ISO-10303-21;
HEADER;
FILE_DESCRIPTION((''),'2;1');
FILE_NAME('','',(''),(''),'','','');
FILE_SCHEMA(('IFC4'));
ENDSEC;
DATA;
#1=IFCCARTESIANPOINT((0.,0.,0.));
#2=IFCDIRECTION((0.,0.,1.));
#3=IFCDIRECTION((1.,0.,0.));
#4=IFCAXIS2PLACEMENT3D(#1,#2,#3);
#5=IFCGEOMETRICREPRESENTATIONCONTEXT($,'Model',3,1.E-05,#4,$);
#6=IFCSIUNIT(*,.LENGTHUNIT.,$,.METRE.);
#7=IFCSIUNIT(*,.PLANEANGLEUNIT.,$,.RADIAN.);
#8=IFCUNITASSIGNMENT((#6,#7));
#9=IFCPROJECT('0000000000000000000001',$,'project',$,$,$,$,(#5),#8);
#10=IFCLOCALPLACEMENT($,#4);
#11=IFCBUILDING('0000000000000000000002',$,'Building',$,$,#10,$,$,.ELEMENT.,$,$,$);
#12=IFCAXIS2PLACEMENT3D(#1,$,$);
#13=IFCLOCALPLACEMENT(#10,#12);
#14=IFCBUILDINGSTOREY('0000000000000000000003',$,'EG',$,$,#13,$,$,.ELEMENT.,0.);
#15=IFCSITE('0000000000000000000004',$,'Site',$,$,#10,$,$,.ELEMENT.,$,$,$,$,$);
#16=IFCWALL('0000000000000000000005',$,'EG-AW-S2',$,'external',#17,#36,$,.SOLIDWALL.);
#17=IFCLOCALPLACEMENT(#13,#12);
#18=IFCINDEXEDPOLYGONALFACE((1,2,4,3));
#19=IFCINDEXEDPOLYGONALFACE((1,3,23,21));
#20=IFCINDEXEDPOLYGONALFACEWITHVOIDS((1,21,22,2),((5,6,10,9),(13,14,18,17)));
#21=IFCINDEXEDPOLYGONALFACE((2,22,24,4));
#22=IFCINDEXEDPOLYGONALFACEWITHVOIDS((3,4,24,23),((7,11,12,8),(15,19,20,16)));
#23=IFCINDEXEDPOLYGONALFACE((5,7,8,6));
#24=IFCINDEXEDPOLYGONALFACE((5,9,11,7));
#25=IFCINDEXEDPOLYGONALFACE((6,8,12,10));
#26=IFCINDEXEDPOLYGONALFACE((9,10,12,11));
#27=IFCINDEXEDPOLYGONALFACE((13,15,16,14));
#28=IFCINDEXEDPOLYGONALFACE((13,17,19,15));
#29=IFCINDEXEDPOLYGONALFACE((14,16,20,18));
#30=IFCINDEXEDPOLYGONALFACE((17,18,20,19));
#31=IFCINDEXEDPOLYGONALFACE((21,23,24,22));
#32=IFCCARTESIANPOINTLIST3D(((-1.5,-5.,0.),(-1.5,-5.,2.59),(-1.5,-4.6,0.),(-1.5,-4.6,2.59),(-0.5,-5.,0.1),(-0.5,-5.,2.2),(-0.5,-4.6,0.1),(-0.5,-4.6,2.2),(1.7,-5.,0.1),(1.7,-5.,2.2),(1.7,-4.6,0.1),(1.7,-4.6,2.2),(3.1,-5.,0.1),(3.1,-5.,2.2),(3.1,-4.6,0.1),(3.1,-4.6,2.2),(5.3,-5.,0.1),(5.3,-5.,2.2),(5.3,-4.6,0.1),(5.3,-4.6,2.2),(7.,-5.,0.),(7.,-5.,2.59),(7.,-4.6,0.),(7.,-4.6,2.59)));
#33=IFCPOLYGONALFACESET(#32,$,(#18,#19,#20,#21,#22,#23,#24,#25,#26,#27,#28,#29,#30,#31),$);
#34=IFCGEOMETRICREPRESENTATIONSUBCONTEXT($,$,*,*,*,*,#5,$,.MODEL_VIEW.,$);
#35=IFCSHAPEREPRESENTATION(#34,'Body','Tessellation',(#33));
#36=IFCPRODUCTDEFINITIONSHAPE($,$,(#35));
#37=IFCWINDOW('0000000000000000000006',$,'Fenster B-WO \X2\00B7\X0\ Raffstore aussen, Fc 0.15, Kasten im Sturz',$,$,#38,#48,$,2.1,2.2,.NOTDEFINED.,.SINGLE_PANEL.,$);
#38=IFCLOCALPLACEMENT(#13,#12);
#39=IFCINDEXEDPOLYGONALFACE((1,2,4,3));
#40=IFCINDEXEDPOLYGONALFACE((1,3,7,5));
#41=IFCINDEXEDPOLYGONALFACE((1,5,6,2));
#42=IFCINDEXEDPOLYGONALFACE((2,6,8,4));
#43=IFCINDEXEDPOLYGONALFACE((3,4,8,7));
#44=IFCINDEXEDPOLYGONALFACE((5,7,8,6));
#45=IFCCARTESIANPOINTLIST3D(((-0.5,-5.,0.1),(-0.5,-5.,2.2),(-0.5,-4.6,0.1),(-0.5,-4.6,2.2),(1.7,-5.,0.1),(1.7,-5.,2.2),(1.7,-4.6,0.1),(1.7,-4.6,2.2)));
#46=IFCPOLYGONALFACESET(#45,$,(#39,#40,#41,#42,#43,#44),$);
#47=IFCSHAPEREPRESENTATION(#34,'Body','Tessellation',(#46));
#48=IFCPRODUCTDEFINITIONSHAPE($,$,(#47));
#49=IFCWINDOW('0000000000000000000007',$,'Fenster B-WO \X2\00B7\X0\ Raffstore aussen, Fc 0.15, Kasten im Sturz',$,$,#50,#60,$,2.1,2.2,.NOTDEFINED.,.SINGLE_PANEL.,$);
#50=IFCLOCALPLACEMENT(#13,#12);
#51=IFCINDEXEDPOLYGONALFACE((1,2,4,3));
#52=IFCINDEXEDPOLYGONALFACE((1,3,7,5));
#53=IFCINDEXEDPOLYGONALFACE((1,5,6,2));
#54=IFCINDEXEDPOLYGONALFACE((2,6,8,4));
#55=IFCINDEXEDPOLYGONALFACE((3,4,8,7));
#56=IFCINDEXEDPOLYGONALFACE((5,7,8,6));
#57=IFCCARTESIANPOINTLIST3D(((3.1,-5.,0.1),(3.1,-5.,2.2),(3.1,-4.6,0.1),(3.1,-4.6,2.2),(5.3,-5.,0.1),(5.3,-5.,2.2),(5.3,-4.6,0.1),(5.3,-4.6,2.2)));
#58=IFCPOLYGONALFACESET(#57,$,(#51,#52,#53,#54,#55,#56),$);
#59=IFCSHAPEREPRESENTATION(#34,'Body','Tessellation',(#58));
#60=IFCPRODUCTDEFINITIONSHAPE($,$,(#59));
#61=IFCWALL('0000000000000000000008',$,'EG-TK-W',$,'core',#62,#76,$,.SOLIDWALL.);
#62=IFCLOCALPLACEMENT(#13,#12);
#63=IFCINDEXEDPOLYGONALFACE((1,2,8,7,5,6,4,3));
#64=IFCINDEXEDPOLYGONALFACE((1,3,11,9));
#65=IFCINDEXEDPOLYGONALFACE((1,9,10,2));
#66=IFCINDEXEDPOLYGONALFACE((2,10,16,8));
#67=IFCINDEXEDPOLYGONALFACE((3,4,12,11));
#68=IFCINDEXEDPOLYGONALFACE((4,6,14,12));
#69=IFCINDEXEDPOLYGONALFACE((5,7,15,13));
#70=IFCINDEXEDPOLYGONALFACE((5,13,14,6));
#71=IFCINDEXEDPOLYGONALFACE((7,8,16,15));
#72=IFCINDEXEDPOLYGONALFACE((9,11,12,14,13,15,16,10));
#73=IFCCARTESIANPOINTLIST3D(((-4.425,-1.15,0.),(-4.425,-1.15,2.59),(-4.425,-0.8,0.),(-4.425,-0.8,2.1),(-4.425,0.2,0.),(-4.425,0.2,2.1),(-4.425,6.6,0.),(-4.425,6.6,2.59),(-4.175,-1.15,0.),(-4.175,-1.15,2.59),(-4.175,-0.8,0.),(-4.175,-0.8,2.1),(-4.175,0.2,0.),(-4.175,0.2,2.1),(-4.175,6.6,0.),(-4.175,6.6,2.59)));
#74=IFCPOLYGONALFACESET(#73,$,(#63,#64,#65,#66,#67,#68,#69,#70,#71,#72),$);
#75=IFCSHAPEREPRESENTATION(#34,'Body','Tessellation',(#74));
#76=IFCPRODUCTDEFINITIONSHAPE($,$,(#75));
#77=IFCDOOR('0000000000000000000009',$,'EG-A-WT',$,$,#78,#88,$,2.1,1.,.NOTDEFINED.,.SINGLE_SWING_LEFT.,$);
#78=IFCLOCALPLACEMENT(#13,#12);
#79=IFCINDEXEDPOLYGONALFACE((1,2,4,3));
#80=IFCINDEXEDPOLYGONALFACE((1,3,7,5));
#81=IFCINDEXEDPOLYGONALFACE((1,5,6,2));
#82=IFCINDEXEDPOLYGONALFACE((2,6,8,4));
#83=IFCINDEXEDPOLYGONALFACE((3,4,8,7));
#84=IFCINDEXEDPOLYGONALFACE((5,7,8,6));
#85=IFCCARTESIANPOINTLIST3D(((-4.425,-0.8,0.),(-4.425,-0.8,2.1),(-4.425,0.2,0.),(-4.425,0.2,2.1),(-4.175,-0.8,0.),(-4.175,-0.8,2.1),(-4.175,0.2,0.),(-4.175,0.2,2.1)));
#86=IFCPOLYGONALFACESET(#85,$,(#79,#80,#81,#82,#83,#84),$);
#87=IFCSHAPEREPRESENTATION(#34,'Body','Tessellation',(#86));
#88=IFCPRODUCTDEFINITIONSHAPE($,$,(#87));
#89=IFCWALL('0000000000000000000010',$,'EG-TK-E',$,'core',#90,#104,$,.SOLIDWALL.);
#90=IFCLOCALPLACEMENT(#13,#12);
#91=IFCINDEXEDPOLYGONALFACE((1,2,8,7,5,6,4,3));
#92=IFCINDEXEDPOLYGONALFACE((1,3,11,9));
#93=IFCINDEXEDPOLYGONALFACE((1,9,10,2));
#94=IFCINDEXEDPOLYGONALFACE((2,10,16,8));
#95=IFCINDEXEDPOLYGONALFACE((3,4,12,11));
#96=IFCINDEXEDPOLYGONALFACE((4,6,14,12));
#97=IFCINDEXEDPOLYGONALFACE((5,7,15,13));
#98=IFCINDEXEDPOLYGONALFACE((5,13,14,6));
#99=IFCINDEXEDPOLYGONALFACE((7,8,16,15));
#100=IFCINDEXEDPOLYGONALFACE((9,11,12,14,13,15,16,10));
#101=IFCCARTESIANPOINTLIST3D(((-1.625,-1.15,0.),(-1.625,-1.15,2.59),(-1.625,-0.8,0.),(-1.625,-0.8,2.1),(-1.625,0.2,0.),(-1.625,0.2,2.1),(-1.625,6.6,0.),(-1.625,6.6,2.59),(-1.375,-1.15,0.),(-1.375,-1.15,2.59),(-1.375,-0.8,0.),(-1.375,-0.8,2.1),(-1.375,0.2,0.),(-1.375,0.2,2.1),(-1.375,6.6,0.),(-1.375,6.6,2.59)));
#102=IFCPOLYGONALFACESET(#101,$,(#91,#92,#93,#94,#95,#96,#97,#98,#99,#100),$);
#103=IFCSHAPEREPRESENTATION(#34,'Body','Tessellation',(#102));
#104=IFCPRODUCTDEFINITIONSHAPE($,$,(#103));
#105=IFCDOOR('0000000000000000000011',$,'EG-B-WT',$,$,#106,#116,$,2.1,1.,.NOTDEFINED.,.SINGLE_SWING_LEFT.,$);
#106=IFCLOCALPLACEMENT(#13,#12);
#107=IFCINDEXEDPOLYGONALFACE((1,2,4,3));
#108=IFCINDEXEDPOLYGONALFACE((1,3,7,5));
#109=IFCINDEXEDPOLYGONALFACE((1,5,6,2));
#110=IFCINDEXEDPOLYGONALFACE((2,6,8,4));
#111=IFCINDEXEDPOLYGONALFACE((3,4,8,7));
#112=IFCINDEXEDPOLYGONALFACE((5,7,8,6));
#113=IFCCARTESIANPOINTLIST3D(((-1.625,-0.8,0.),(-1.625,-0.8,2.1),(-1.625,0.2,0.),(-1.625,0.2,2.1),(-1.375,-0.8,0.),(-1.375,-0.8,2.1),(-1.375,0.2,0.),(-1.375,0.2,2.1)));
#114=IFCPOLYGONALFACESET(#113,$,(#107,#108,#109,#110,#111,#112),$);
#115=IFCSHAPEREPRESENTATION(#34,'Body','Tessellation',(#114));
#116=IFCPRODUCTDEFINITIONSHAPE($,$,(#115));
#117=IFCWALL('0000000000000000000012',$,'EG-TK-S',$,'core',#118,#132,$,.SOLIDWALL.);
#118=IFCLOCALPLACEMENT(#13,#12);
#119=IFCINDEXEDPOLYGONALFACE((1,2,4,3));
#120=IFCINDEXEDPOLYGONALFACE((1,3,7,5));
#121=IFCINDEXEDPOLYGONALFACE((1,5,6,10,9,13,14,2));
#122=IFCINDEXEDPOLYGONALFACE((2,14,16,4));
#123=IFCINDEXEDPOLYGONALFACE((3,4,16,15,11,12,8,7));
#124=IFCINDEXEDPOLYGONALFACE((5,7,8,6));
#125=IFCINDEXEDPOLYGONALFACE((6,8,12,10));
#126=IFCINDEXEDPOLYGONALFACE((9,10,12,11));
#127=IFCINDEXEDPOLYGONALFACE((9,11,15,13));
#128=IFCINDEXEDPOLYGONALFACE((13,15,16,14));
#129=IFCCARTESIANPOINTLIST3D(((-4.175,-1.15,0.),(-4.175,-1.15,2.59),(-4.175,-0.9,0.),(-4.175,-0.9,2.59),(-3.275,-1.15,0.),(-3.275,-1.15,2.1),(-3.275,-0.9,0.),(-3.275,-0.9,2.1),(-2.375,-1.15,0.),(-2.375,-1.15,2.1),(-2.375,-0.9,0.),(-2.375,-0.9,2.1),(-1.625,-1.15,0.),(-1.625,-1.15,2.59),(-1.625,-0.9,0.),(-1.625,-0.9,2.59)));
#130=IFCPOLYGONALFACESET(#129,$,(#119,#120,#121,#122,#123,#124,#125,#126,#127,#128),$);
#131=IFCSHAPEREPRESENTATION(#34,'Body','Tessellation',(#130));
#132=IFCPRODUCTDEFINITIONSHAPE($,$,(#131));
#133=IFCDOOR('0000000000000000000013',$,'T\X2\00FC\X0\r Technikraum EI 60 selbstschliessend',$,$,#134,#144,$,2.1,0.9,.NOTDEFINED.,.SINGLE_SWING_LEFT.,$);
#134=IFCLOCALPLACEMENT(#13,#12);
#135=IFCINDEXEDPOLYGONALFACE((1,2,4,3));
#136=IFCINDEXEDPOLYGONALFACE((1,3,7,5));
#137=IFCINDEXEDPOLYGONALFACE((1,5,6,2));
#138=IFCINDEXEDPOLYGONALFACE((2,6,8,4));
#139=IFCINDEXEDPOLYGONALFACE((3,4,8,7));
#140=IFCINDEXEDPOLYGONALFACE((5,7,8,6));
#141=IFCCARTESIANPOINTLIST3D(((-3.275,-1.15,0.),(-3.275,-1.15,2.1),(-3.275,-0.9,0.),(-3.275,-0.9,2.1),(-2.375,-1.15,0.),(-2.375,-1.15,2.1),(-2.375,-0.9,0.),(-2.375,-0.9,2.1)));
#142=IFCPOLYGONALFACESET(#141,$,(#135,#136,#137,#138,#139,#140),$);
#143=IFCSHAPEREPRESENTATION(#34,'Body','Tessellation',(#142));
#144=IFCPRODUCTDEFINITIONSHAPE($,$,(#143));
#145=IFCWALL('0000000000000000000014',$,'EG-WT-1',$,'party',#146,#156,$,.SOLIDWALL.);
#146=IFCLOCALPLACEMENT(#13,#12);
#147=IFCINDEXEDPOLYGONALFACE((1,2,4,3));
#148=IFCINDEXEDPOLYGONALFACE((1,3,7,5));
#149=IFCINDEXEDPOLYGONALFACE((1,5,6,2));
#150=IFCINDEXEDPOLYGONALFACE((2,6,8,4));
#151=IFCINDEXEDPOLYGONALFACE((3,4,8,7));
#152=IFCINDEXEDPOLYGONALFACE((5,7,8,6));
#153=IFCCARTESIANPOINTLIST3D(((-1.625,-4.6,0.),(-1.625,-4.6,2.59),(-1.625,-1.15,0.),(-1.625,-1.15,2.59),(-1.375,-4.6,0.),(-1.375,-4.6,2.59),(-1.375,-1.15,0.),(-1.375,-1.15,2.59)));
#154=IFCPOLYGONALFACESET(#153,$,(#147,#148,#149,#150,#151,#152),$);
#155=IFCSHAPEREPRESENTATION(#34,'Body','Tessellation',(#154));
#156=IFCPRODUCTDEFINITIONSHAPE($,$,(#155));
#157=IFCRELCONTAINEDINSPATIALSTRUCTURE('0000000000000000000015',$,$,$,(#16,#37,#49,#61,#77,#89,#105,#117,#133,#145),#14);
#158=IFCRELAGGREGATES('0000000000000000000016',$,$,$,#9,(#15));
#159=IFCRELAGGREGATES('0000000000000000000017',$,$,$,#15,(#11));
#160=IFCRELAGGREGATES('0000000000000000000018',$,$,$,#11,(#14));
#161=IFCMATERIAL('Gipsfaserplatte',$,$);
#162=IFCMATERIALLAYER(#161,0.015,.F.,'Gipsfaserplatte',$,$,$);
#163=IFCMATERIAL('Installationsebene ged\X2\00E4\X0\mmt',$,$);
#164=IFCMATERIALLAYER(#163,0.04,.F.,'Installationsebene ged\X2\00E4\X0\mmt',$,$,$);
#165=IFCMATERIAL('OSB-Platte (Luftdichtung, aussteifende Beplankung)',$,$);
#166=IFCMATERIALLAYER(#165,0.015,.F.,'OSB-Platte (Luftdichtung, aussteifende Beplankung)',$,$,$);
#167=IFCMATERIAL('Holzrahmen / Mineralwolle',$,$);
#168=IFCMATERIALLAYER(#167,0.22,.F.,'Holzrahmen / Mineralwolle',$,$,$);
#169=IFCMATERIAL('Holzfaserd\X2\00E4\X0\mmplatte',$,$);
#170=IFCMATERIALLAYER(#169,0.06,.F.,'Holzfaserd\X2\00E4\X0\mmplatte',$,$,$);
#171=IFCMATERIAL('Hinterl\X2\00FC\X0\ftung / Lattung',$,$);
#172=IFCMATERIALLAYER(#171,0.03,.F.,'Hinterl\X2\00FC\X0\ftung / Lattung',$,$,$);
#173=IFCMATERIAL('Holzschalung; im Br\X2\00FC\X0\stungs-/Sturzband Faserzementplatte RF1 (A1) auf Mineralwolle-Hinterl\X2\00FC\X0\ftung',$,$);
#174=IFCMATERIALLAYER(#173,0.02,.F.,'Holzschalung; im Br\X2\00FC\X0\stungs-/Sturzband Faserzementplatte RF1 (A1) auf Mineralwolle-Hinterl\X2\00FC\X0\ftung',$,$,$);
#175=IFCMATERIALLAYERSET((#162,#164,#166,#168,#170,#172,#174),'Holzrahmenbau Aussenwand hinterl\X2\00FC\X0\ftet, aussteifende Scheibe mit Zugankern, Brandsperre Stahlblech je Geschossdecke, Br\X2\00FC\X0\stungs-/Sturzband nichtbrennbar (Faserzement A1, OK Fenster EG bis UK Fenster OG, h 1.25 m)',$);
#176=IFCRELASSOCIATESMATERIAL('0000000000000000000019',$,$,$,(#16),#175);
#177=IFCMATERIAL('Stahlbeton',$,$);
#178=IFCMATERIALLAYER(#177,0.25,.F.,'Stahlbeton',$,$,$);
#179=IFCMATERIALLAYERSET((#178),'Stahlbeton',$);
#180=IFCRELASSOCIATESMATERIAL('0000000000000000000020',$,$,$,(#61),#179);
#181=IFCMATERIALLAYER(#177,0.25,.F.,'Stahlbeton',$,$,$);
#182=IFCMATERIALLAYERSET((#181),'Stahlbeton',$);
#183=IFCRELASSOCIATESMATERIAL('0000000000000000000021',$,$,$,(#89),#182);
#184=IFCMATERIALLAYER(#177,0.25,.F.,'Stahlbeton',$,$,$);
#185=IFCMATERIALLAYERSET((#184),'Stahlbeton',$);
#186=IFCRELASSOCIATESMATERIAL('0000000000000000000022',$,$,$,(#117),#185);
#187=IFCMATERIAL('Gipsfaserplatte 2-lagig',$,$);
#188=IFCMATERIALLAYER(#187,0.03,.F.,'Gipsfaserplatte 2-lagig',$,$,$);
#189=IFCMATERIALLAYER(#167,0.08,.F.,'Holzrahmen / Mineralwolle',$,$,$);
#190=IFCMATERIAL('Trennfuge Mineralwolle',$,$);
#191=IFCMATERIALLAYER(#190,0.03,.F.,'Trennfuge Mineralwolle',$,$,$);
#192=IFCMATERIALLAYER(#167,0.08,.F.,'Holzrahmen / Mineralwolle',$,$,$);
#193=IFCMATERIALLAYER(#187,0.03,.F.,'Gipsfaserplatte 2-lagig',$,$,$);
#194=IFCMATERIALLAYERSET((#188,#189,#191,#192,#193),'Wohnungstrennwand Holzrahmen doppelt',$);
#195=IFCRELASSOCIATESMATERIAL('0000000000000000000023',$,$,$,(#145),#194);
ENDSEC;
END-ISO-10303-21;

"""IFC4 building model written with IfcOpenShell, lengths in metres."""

from ifc_helpers import new_model, si_unit, frame, frame_2d, origin, origin_with_axes, place, context, subcontext, project, spatial, rectangle, extrude, material, layer, layer_set, element, fill, save


model = new_model("IFC4")

# Units and contexts
model_context = context("Model", 3, precision=1e-05, world=origin_with_axes())
sub_context = subcontext(model_context, None, None, "MODEL_VIEW")
ifc_project = project(units=[si_unit("LENGTHUNIT", "METRE"), si_unit("PLANEANGLEUNIT", "RADIAN")], contexts=[model_context])

# Site, building, storey
placement = place(None, origin_with_axes())
site = spatial("IfcSite", under=ifc_project, at=placement, Name="Site", CompositionType="ELEMENT")
building = spatial("IfcBuilding", under=site, at=placement, Name="Building", CompositionType="ELEMENT")
storey_placement = place(placement, origin())
storey = spatial("IfcBuildingStorey", under=building, at=storey_placement, Name="EG", CompositionType="ELEMENT", Elevation=0.0)

# Wall, openings, windows
ifc_material_1 = material(Name="Gipsfaserplatte")
ifc_layer_1 = layer(ifc_material_1, 0.015, ventilated=False, Name="Gipsfaserplatte")
ifc_material_2 = material(Name="Installationsebene gedämmt")
ifc_layer_2 = layer(ifc_material_2, 0.04, ventilated=False, Name="Installationsebene gedämmt")
ifc_material_3 = material(Name="OSB-Platte (Luftdichtung, aussteifende Beplankung)")
ifc_layer_3 = layer(ifc_material_3, 0.015, ventilated=False, Name="OSB-Platte (Luftdichtung, aussteifende Beplankung)")
ifc_material_4 = material(Name="Holzrahmen / Mineralwolle")
ifc_layer_4 = layer(ifc_material_4, 0.22, ventilated=False, Name="Holzrahmen / Mineralwolle")
ifc_material_5 = material(Name="Holzfaserdämmplatte")
ifc_layer_5 = layer(ifc_material_5, 0.06, ventilated=False, Name="Holzfaserdämmplatte")
ifc_material_6 = material(Name="Hinterlüftung / Lattung")
ifc_layer_6 = layer(ifc_material_6, 0.03, ventilated=False, Name="Hinterlüftung / Lattung")
ifc_material_7 = material(Name="Holzschalung; im Brüstungs-/Sturzband Faserzementplatte RF1 (A1) auf Mineralwolle-Hinterlüftung")
ifc_layer_7 = layer(ifc_material_7, 0.02, ventilated=False, Name="Holzschalung; im Brüstungs-/Sturzband Faserzementplatte RF1 (A1) auf Mineralwolle-Hinterlüftung")
ifc_layer_set_1 = layer_set([ifc_layer_1, ifc_layer_2, ifc_layer_3, ifc_layer_4, ifc_layer_5, ifc_layer_6, ifc_layer_7], Name="Holzrahmenbau Aussenwand hinterlüftet, aussteifende Scheibe mit Zugankern, Brandsperre Stahlblech je Geschossdecke, Brüstungs-/Sturzband nichtbrennbar (Faserzement A1, OK Fenster EG bis UK Fenster OG, h 1.25 m)")
wall_1_placement = place(storey_placement, frame((7.0, -4.8, 0.0), z_axis=(0.0, 0.0, 1.0), x_axis=(-1.0, 0.0, 0.0)))
wall_1 = element("IfcWall", 1, at=wall_1_placement, inside=storey, material=ifc_layer_set_1, Name="EG-AW-S2", ObjectType="external", PredefinedType="SOLIDWALL", context=sub_context, shape_type="SweptSolid", body=[
    extrude(rectangle(XDim=8.5, YDim=0.4, at=frame_2d((4.25, 0.0))), origin(), (0.0, 0.0, 1.0), 2.59),
])
opening_1_placement = place(wall_1_placement, frame((6.4, 0.25, 0.1), z_axis=(0.0, -1.0, 0.0), x_axis=(1.0, 0.0, 0.0)))
opening_1 = element("IfcOpeningElement", 2, at=opening_1_placement, cuts=wall_1, PredefinedType="OPENING", context=sub_context, shape_type="SweptSolid", body=[
    extrude(rectangle(XDim=2.2, YDim=2.1, at=frame_2d((0.0, 1.05))), origin(), (0.0, 0.0, 1.0), 0.5),
])
opening_2_placement = place(wall_1_placement, frame((2.8, 0.25, 0.1), z_axis=(0.0, -1.0, 0.0), x_axis=(1.0, 0.0, 0.0)))
opening_2 = element("IfcOpeningElement", 3, at=opening_2_placement, cuts=wall_1, PredefinedType="OPENING", context=sub_context, shape_type="SweptSolid", body=[
    extrude(rectangle(XDim=2.2, YDim=2.1, at=frame_2d((0.0, 1.05))), origin(), (0.0, 0.0, 1.0), 0.5),
])
window_1_placement = place(wall_1_placement, frame((6.4, 0.2, 0.1), z_axis=(0.0, -1.0, 0.0), x_axis=(1.0, 0.0, 0.0)))
window_1 = element("IfcWindow", 4, at=window_1_placement, inside=storey, Name="Fenster B-WO · Raffstore aussen, Fc 0.15, Kasten im Sturz", OverallHeight=2.1, OverallWidth=2.2, PartitioningType="SINGLE_PANEL", PredefinedType="NOTDEFINED", context=sub_context, shape_type="SweptSolid", body=[
    extrude(rectangle(XDim=2.2, YDim=2.1, at=frame_2d((0.0, 1.05))), origin(), (0.0, 0.0, 1.0), 0.4),
])
fill(opening_1, window_1)
window_2_placement = place(wall_1_placement, frame((2.8, 0.2, 0.1), z_axis=(0.0, -1.0, 0.0), x_axis=(1.0, 0.0, 0.0)))
window_2 = element("IfcWindow", 5, at=window_2_placement, inside=storey, Name="Fenster B-WO · Raffstore aussen, Fc 0.15, Kasten im Sturz", OverallHeight=2.1, OverallWidth=2.2, PartitioningType="SINGLE_PANEL", PredefinedType="NOTDEFINED", context=sub_context, shape_type="SweptSolid", body=[
    extrude(rectangle(XDim=2.2, YDim=2.1, at=frame_2d((0.0, 1.05))), origin(), (0.0, 0.0, 1.0), 0.4),
])
fill(opening_2, window_2)

# Walls, openings, doors
ifc_material_8 = material(Name="Stahlbeton")
ifc_layer_8 = layer(ifc_material_8, 0.25, ventilated=False, Name="Stahlbeton")
ifc_layer_set_2 = layer_set([ifc_layer_8], Name="Stahlbeton")
wall_2_placement = place(storey_placement, frame((-4.3, -1.15, 0.0), z_axis=(0.0, 0.0, 1.0), x_axis=(0.0, 1.0, 0.0)))
wall_2 = element("IfcWall", 6, at=wall_2_placement, inside=storey, material=ifc_layer_set_2, Name="EG-TK-W", ObjectType="core", PredefinedType="SOLIDWALL", context=sub_context, shape_type="SweptSolid", body=[
    extrude(rectangle(XDim=7.75, YDim=0.25, at=frame_2d((3.875, 0.0))), origin(), (0.0, 0.0, 1.0), 2.59),
])
opening_3_placement = place(wall_2_placement, frame((0.85, 0.175, 0.0), z_axis=(0.0, -1.0, 0.0), x_axis=(1.0, 0.0, 0.0)))
opening_3 = element("IfcOpeningElement", 7, at=opening_3_placement, cuts=wall_2, PredefinedType="OPENING", context=sub_context, shape_type="SweptSolid", body=[
    extrude(rectangle(XDim=1.0, YDim=2.1, at=frame_2d((0.0, 1.05))), origin(), (0.0, 0.0, 1.0), 0.35),
])
door_1_placement = place(wall_2_placement, frame((0.85, 0.125, 0.0), z_axis=(0.0, -1.0, 0.0), x_axis=(1.0, 0.0, 0.0)))
door_1 = element("IfcDoor", 8, at=door_1_placement, inside=storey, Name="EG-A-WT", OperationType="SINGLE_SWING_LEFT", OverallHeight=2.1, OverallWidth=1.0, PredefinedType="NOTDEFINED", context=sub_context, shape_type="SweptSolid", body=[
    extrude(rectangle(XDim=1.0, YDim=2.1, at=frame_2d((0.0, 1.05))), origin(), (0.0, 0.0, 1.0), 0.25),
])
fill(opening_3, door_1)
ifc_layer_9 = layer(ifc_material_8, 0.25, ventilated=False, Name="Stahlbeton")
ifc_layer_set_3 = layer_set([ifc_layer_9], Name="Stahlbeton")
wall_3_placement = place(storey_placement, frame((-1.5, -1.15, 0.0), z_axis=(0.0, 0.0, 1.0), x_axis=(0.0, 1.0, 0.0)))
wall_3 = element("IfcWall", 9, at=wall_3_placement, inside=storey, material=ifc_layer_set_3, Name="EG-TK-E", ObjectType="core", PredefinedType="SOLIDWALL", context=sub_context, shape_type="SweptSolid", body=[
    extrude(rectangle(XDim=7.75, YDim=0.25, at=frame_2d((3.875, 0.0))), origin(), (0.0, 0.0, 1.0), 2.59),
])
opening_4_placement = place(wall_3_placement, frame((0.85, 0.175, 0.0), z_axis=(0.0, -1.0, 0.0), x_axis=(1.0, 0.0, 0.0)))
opening_4 = element("IfcOpeningElement", 10, at=opening_4_placement, cuts=wall_3, PredefinedType="OPENING", context=sub_context, shape_type="SweptSolid", body=[
    extrude(rectangle(XDim=1.0, YDim=2.1, at=frame_2d((0.0, 1.05))), origin(), (0.0, 0.0, 1.0), 0.35),
])
door_2_placement = place(wall_3_placement, frame((0.85, 0.125, 0.0), z_axis=(0.0, -1.0, 0.0), x_axis=(1.0, 0.0, 0.0)))
door_2 = element("IfcDoor", 11, at=door_2_placement, inside=storey, Name="EG-B-WT", OperationType="SINGLE_SWING_LEFT", OverallHeight=2.1, OverallWidth=1.0, PredefinedType="NOTDEFINED", context=sub_context, shape_type="SweptSolid", body=[
    extrude(rectangle(XDim=1.0, YDim=2.1, at=frame_2d((0.0, 1.05))), origin(), (0.0, 0.0, 1.0), 0.25),
])
fill(opening_4, door_2)
ifc_layer_10 = layer(ifc_material_8, 0.25, ventilated=False, Name="Stahlbeton")
ifc_layer_set_4 = layer_set([ifc_layer_10], Name="Stahlbeton")
wall_4_placement = place(storey_placement, frame((-4.175, -1.025, 0.0), z_axis=(0.0, 0.0, 1.0), x_axis=(1.0, 0.0, 0.0)))
wall_4 = element("IfcWall", 12, at=wall_4_placement, inside=storey, material=ifc_layer_set_4, Name="EG-TK-S", ObjectType="core", PredefinedType="SOLIDWALL", context=sub_context, shape_type="SweptSolid", body=[
    extrude(rectangle(XDim=2.55, YDim=0.25, at=frame_2d((1.275, 0.0))), origin(), (0.0, 0.0, 1.0), 2.59),
])
opening_5_placement = place(wall_4_placement, frame((1.35, 0.175, 0.0), z_axis=(0.0, -1.0, 0.0), x_axis=(1.0, 0.0, 0.0)))
opening_5 = element("IfcOpeningElement", 13, at=opening_5_placement, cuts=wall_4, PredefinedType="OPENING", context=sub_context, shape_type="SweptSolid", body=[
    extrude(rectangle(XDim=0.9, YDim=2.1, at=frame_2d((0.0, 1.05))), origin(), (0.0, 0.0, 1.0), 0.35),
])
door_3_placement = place(wall_4_placement, frame((1.35, 0.125, 0.0), z_axis=(0.0, -1.0, 0.0), x_axis=(1.0, 0.0, 0.0)))
door_3 = element("IfcDoor", 14, at=door_3_placement, inside=storey, Name="Tür Technikraum EI 60 selbstschliessend", OperationType="SINGLE_SWING_LEFT", OverallHeight=2.1, OverallWidth=0.9, PredefinedType="NOTDEFINED", context=sub_context, shape_type="SweptSolid", body=[
    extrude(rectangle(XDim=0.9, YDim=2.1, at=frame_2d((0.0, 1.05))), origin(), (0.0, 0.0, 1.0), 0.25),
])
fill(opening_5, door_3)

# Wall
ifc_material_9 = material(Name="Gipsfaserplatte 2-lagig")
ifc_layer_11 = layer(ifc_material_9, 0.03, ventilated=False, Name="Gipsfaserplatte 2-lagig")
ifc_layer_12 = layer(ifc_material_4, 0.08, ventilated=False, Name="Holzrahmen / Mineralwolle")
ifc_material_10 = material(Name="Trennfuge Mineralwolle")
ifc_layer_13 = layer(ifc_material_10, 0.03, ventilated=False, Name="Trennfuge Mineralwolle")
ifc_layer_14 = layer(ifc_material_4, 0.08, ventilated=False, Name="Holzrahmen / Mineralwolle")
ifc_layer_15 = layer(ifc_material_9, 0.03, ventilated=False, Name="Gipsfaserplatte 2-lagig")
ifc_layer_set_5 = layer_set([ifc_layer_11, ifc_layer_12, ifc_layer_13, ifc_layer_14, ifc_layer_15], Name="Wohnungstrennwand Holzrahmen doppelt")
wall_5_placement = place(storey_placement, frame((-1.5, -1.15, 0.0), z_axis=(0.0, 0.0, 1.0), x_axis=(0.0, -1.0, 0.0)))
element("IfcWall", 15, at=wall_5_placement, inside=storey, material=ifc_layer_set_5, Name="EG-WT-1", ObjectType="party", PredefinedType="SOLIDWALL", context=sub_context, shape_type="SweptSolid", body=[
    extrude(rectangle(XDim=3.45, YDim=0.25, at=frame_2d((1.725, 0.0))), origin(), (0.0, 0.0, 1.0), 2.59),
])

save(model, "model.ifc")
